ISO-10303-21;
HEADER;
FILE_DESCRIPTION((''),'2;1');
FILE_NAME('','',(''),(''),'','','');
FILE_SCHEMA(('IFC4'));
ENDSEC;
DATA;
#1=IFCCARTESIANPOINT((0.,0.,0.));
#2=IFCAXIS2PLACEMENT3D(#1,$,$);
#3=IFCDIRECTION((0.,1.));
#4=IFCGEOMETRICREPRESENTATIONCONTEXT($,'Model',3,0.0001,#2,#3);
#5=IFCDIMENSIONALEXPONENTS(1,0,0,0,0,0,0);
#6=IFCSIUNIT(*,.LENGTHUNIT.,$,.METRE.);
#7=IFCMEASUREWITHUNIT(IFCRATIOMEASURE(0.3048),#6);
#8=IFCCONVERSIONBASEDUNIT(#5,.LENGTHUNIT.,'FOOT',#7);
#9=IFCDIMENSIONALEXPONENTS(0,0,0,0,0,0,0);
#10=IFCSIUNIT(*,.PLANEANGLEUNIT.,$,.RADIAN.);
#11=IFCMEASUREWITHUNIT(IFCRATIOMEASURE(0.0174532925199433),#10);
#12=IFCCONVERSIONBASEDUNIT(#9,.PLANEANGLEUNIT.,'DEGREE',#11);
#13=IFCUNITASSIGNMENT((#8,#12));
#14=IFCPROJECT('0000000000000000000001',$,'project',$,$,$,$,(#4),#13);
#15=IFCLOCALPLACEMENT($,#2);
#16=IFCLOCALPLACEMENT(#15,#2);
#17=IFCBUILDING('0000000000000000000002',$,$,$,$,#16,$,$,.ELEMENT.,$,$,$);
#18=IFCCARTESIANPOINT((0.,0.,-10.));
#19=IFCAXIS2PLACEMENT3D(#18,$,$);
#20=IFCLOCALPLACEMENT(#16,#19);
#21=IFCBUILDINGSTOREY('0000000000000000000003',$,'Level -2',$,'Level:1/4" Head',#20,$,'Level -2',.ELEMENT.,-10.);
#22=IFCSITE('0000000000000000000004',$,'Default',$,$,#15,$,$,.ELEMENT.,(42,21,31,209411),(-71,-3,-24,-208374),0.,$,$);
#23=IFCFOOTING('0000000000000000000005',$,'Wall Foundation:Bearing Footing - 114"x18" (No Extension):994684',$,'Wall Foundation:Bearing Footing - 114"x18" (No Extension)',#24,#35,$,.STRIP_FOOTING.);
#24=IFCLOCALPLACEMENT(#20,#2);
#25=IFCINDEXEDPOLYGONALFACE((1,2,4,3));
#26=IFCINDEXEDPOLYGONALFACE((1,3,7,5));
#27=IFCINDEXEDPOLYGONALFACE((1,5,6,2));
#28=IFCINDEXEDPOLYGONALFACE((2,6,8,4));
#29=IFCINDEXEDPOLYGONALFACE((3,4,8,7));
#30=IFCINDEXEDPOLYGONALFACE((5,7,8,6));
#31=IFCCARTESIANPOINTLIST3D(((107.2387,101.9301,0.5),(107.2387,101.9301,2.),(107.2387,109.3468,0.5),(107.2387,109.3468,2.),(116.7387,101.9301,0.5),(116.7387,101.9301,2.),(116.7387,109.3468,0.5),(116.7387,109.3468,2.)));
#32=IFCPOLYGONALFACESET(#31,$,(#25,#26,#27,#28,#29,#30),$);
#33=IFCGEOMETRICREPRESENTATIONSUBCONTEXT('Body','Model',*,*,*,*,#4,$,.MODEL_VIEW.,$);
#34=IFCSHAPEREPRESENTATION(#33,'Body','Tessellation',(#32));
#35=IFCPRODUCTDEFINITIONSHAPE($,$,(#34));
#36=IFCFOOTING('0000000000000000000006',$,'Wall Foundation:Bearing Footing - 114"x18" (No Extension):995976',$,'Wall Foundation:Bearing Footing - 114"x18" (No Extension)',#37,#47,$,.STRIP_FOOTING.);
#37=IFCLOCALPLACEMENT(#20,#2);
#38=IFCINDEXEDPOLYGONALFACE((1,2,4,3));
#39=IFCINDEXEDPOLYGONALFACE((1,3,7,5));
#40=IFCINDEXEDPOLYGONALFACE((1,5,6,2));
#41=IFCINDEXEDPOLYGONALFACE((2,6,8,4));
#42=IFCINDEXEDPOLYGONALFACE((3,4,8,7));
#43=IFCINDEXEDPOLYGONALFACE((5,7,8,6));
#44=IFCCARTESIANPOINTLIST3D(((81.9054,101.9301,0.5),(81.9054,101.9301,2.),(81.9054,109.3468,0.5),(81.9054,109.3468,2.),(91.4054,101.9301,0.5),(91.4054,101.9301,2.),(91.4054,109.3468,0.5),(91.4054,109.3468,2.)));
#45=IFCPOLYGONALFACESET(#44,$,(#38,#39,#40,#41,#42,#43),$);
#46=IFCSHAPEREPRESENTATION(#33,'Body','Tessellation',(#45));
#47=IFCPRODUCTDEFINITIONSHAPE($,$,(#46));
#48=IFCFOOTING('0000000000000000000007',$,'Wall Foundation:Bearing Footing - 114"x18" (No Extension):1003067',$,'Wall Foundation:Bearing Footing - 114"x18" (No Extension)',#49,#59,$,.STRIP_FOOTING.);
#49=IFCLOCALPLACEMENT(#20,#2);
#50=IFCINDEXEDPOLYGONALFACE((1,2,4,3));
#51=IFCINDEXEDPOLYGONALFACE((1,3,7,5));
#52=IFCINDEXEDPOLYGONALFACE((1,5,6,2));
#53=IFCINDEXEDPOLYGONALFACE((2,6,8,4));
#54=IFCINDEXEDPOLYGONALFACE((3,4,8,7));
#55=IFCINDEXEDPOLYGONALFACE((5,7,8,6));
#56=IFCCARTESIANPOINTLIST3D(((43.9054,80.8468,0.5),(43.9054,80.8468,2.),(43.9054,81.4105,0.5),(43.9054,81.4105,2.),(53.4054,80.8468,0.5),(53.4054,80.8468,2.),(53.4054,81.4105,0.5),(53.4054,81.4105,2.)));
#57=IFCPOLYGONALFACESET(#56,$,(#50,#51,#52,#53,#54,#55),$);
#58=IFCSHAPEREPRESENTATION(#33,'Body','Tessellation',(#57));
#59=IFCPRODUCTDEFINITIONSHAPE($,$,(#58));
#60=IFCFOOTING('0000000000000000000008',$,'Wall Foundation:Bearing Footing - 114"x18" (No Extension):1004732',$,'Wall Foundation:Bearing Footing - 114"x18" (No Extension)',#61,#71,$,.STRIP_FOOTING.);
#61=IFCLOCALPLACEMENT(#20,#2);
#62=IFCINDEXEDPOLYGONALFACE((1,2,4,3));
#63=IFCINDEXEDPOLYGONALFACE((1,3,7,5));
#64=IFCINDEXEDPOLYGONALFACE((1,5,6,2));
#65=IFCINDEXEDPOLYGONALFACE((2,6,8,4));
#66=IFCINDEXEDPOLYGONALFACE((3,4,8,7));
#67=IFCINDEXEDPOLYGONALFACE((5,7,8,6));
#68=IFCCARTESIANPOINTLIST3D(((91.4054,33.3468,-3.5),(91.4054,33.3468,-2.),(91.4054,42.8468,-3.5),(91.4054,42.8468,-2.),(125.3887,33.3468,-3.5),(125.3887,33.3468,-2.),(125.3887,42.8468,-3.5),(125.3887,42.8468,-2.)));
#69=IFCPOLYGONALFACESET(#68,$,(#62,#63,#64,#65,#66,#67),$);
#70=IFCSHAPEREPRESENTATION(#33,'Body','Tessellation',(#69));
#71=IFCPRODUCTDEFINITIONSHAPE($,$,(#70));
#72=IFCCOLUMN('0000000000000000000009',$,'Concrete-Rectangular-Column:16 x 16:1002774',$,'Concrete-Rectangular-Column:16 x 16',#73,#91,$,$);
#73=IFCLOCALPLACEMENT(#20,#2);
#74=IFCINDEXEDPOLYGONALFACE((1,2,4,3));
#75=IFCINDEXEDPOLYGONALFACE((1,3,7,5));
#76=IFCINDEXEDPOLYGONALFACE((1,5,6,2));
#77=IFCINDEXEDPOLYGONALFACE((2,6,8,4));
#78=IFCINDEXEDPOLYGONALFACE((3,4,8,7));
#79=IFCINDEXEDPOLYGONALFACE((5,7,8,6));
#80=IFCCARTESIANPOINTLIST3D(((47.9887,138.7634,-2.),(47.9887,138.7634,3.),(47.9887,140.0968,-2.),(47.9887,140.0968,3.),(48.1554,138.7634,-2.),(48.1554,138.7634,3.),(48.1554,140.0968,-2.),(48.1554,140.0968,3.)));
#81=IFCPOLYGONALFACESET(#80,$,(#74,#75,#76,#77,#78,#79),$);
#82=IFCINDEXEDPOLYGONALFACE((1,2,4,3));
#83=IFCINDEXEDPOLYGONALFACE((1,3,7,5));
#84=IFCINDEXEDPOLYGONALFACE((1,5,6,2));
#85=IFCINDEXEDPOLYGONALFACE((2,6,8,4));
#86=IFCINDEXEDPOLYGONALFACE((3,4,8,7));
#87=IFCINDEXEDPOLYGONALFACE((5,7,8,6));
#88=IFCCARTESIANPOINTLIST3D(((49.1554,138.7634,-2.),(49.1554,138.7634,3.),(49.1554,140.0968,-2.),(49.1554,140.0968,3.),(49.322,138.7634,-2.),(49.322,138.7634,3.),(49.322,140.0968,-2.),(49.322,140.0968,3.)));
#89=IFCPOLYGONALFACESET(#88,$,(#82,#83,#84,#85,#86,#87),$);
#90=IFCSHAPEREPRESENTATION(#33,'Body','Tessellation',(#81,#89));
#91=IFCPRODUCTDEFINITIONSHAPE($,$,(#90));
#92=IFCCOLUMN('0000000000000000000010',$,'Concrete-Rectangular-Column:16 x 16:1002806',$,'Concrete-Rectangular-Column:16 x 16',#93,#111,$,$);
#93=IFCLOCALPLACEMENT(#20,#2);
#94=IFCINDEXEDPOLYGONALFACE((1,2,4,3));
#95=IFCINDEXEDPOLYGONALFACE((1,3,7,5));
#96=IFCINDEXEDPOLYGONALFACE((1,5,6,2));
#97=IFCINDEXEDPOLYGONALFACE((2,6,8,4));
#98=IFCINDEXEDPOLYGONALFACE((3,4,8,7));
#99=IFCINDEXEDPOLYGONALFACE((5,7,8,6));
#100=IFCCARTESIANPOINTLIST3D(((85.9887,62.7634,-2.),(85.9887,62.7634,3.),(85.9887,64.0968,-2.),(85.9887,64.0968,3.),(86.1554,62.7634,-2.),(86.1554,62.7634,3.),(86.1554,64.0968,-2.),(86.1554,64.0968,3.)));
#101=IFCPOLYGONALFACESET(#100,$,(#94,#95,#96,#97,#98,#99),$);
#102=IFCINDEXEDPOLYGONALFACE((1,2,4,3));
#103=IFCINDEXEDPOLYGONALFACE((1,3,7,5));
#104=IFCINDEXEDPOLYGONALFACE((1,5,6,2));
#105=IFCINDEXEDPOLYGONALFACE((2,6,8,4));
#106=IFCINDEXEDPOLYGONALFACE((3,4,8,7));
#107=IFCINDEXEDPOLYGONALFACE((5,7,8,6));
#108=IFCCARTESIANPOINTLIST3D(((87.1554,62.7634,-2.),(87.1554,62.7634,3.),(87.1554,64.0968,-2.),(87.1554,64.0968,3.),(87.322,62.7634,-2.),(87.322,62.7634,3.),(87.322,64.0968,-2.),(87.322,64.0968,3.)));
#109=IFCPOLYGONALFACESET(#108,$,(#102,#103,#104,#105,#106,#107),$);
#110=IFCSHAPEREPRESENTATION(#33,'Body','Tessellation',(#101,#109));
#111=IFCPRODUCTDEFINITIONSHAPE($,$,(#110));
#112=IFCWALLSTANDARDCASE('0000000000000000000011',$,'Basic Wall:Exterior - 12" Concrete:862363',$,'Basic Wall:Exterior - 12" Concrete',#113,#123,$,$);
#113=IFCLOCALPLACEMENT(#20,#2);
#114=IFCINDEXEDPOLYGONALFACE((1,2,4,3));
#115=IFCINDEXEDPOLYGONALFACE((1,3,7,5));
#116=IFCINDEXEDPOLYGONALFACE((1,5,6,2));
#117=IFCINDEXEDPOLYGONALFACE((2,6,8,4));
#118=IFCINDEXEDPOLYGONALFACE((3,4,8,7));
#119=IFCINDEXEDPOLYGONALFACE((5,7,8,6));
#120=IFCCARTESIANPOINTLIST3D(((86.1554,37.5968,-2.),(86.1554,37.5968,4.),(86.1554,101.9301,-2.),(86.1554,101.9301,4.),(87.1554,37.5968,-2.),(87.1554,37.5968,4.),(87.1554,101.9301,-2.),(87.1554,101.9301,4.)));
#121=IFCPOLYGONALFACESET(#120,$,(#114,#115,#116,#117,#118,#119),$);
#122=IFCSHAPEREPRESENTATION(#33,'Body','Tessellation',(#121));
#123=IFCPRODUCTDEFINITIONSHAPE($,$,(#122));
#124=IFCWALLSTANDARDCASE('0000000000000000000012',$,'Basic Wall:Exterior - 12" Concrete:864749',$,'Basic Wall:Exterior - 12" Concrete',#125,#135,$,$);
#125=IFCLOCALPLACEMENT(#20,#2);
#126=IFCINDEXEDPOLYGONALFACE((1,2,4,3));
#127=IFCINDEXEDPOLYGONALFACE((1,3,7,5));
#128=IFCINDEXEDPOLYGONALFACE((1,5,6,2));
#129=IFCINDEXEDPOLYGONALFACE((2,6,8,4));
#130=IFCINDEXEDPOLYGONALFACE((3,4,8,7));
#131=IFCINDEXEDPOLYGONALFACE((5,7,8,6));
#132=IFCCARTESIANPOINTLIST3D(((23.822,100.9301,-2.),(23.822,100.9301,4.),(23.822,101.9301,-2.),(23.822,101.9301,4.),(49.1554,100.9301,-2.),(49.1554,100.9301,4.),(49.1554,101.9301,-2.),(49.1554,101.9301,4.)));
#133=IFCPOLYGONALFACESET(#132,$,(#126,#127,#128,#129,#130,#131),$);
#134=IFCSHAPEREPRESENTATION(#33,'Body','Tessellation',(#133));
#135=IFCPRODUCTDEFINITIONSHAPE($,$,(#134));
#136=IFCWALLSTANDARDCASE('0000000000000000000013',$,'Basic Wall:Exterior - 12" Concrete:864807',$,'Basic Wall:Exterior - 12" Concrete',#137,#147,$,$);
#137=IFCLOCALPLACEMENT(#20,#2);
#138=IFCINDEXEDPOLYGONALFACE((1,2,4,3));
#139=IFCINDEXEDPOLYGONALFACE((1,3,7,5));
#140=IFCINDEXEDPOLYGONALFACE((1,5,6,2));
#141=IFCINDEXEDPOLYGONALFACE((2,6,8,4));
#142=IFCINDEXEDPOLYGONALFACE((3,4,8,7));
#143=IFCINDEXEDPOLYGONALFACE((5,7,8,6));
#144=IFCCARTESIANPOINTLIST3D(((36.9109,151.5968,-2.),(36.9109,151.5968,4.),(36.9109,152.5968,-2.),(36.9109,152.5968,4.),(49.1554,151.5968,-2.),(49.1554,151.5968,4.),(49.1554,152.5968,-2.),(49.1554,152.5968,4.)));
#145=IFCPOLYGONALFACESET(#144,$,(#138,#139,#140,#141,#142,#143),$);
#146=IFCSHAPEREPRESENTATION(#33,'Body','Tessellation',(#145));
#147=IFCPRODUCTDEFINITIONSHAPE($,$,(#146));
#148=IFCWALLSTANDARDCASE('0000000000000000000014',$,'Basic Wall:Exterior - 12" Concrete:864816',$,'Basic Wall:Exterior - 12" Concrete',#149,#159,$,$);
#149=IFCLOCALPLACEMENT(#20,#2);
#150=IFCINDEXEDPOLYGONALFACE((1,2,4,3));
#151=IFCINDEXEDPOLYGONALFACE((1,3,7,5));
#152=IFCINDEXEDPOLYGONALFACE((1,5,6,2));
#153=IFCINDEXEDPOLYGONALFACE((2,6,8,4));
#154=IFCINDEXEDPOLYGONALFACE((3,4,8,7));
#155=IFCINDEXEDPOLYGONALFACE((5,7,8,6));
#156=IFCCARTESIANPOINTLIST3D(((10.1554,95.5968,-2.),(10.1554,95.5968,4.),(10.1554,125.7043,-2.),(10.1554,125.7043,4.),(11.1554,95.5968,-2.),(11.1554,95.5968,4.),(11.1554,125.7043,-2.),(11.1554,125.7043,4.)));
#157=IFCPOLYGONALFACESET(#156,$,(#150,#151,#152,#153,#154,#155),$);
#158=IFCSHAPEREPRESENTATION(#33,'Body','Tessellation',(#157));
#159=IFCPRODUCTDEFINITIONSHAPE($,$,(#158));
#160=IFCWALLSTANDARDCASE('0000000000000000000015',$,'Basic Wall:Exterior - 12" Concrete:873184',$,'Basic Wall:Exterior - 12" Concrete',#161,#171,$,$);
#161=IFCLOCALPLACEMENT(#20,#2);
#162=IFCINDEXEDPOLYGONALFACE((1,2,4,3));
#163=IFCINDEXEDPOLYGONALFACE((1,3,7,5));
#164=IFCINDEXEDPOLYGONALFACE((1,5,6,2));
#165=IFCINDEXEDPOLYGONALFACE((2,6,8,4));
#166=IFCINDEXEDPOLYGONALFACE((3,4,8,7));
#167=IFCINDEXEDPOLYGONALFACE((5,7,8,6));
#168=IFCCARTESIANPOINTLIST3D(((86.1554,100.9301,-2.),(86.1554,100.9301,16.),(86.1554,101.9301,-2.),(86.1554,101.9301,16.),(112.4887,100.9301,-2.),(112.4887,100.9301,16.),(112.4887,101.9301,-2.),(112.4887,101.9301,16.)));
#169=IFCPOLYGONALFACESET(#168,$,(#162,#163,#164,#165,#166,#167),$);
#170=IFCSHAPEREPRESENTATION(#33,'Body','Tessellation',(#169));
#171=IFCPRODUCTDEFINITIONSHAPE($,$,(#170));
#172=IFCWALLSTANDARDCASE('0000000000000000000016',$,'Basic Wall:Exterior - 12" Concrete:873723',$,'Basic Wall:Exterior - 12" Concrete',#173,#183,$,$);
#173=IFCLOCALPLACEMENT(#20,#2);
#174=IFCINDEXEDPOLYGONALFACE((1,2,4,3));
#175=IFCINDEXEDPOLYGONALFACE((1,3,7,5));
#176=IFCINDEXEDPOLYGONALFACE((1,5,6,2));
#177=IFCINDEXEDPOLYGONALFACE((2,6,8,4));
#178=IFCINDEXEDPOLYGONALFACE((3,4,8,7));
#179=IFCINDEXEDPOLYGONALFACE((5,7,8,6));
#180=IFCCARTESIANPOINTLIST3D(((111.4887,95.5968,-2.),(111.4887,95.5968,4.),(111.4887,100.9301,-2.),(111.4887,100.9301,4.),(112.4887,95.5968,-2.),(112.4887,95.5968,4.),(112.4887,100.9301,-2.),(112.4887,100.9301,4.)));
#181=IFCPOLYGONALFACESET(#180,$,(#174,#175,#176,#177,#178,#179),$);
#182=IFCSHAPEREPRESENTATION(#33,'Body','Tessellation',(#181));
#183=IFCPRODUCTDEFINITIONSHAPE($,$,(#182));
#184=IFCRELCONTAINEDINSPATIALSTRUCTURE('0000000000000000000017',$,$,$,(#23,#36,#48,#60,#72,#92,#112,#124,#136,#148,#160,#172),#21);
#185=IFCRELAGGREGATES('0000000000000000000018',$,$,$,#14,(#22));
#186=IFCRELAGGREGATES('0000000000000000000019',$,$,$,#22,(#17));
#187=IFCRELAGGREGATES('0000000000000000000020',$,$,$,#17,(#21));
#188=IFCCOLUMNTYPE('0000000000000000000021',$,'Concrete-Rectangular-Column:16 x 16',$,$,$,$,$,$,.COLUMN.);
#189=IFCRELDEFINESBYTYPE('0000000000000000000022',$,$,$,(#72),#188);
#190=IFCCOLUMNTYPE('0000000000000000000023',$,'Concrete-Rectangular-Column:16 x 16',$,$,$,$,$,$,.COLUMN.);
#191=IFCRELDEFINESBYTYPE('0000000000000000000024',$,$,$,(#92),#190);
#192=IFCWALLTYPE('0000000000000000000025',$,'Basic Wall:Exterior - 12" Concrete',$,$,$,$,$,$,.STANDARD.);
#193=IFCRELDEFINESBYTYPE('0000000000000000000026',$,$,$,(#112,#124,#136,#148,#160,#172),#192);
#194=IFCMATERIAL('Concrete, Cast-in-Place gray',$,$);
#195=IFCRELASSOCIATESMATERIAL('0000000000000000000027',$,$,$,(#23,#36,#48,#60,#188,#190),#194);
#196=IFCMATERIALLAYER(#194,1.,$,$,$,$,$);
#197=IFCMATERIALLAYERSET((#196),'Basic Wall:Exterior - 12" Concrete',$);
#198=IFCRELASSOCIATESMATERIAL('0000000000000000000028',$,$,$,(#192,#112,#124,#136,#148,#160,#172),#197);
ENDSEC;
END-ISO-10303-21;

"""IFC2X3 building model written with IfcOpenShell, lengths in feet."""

from ifc_helpers import new_model, entity, si_unit, converted_unit, direction, frame, frame_2d, origin, origin_2d_with_axis, place, context, subcontext, project, spatial, rectangle, extrude, source, transform, mapped, material, layer, layer_set, layer_usage, type_object, type_shapes, element, save


model = new_model("IFC2X3")

# Units and contexts
model_context = context("Model", 3, precision=0.0001, world=origin(), true_north=direction((0.0, 1.0)))
body_context = subcontext(model_context, "Body", "Model", "MODEL_VIEW")
ifc_project = project(units=[converted_unit("LENGTHUNIT", "FOOT", entity("IfcRatioMeasure", 0.3048), si_unit("LENGTHUNIT", "METRE"), dimensions=[1, 0, 0, 0, 0, 0, 0]), converted_unit("PLANEANGLEUNIT", "DEGREE", entity("IfcRatioMeasure", 0.0174532925199433), si_unit("PLANEANGLEUNIT", "RADIAN"), dimensions=[0, 0, 0, 0, 0, 0, 0])], contexts=[model_context])

# Site, building, storey
site_placement = place(None, origin())
site = spatial("IfcSite", under=ifc_project, at=site_placement, Name="Default", CompositionType="ELEMENT", RefLatitude=(42, 21, 31, 209411), RefLongitude=(-71, -3, -24, -208374), RefElevation=0.0)
building_placement = place(site_placement, origin())
building = spatial("IfcBuilding", under=site, at=building_placement, CompositionType="ELEMENT")
storey_placement = place(building_placement, frame((0.0, 0.0, -10.0)))
storey = spatial("IfcBuildingStorey", under=building, at=storey_placement, Name="Level -2", ObjectType="Level:1/4\" Head", LongName="Level -2", CompositionType="ELEMENT", Elevation=-10.0)

# Footings
ifc_material = material(Name="Concrete, Cast-in-Place gray")
footing_1_placement = place(storey_placement, origin())
element("IfcFooting", 1, at=footing_1_placement, inside=storey, material=ifc_material, Name="Wall Foundation:Bearing Footing - 114\"x18\" (No Extension):994684", ObjectType="Wall Foundation:Bearing Footing - 114\"x18\" (No Extension)", PredefinedType="STRIP_FOOTING", context=body_context, shape_type="SweptSolid", body=[
    extrude(rectangle(XDim=7.4167, YDim=9.5, at=frame_2d((0.0, 0.0), x_axis=(1.0, 0.0))), frame((111.9887, 105.6384, 0.5), z_axis=(0.0, 0.0, 1.0), x_axis=(0.0, 1.0, 0.0)), (0.0, 0.0, 1.0), 1.5),
])
footing_2_placement = place(storey_placement, origin())
element("IfcFooting", 2, at=footing_2_placement, inside=storey, material=ifc_material, Name="Wall Foundation:Bearing Footing - 114\"x18\" (No Extension):995976", ObjectType="Wall Foundation:Bearing Footing - 114\"x18\" (No Extension)", PredefinedType="STRIP_FOOTING", context=body_context, shape_type="SweptSolid", body=[
    extrude(rectangle(XDim=7.4167, YDim=9.5, at=frame_2d((0.0, 0.0), x_axis=(1.0, 0.0))), frame((86.6554, 105.6384, 0.5), z_axis=(0.0, 0.0, 1.0), x_axis=(0.0, 1.0, 0.0)), (0.0, 0.0, 1.0), 1.5),
])
footing_3_placement = place(storey_placement, origin())
element("IfcFooting", 3, at=footing_3_placement, inside=storey, material=ifc_material, Name="Wall Foundation:Bearing Footing - 114\"x18\" (No Extension):1003067", ObjectType="Wall Foundation:Bearing Footing - 114\"x18\" (No Extension)", PredefinedType="STRIP_FOOTING", context=body_context, shape_type="SweptSolid", body=[
    extrude(rectangle(XDim=0.5637, YDim=9.5, at=frame_2d((0.0, 0.0), x_axis=(1.0, 0.0))), frame((48.6554, 81.1286, 0.5), z_axis=(0.0, 0.0, 1.0), x_axis=(0.0, -1.0, 0.0)), (0.0, 0.0, 1.0), 1.5),
])
footing_4_placement = place(storey_placement, origin())
element("IfcFooting", 4, at=footing_4_placement, inside=storey, material=ifc_material, Name="Wall Foundation:Bearing Footing - 114\"x18\" (No Extension):1004732", ObjectType="Wall Foundation:Bearing Footing - 114\"x18\" (No Extension)", PredefinedType="STRIP_FOOTING", context=body_context, shape_type="SweptSolid", body=[
    extrude(rectangle(XDim=33.9833, YDim=9.5, at=frame_2d((0.0, 0.0), x_axis=(1.0, 0.0))), frame((108.397, 38.0968, -3.5), z_axis=(0.0, 0.0, 1.0), x_axis=(-1.0, 0.0, 0.0)), (0.0, 0.0, 1.0), 1.5),
])

# Columns
column_type_1 = type_object("IfcColumnType", Name="Concrete-Rectangular-Column:16 x 16", PredefinedType="COLUMN", material=ifc_material)
shared_shape_1 = source(origin(), body_context, "Body", "SweptSolid", [
    extrude(rectangle(XDim=1.3333, YDim=0.1667, at=frame_2d((0.0, 0.0), x_axis=(1.0, 0.0))), frame((48.072, 139.4301, -12.0), z_axis=(0.0, 0.0, 1.0), x_axis=(0.0, -1.0, 0.0)), (0.0, 0.0, 1.0), 5.0),
    extrude(rectangle(XDim=1.3333, YDim=0.1667, at=origin_2d_with_axis()), frame((49.2387, 139.4301, -12.0), z_axis=(0.0, 0.0, 1.0), x_axis=(0.0, -1.0, 0.0)), (0.0, 0.0, 1.0), 5.0),
])
type_shapes(column_type_1, [shared_shape_1])
column_1_placement = place(storey_placement, frame((0.0, 0.0, 10.0)))
element("IfcColumn", 5, at=column_1_placement, inside=storey, type_object=column_type_1, Name="Concrete-Rectangular-Column:16 x 16:1002774", ObjectType="Concrete-Rectangular-Column:16 x 16", context=body_context, shape_type="MappedRepresentation", body=[
    mapped(shared_shape_1, transform((0.0, 0.0, 0.0), scale=1.0)),
])
column_type_2 = type_object("IfcColumnType", Name="Concrete-Rectangular-Column:16 x 16", PredefinedType="COLUMN", material=ifc_material)
shared_shape_2 = source(origin(), body_context, "Body", "SweptSolid", [
    extrude(rectangle(XDim=1.3333, YDim=0.1667, at=frame_2d((0.0, 0.0), x_axis=(1.0, 0.0))), frame((86.072, 63.4301, -12.0), z_axis=(0.0, 0.0, 1.0), x_axis=(0.0, -1.0, 0.0)), (0.0, 0.0, 1.0), 5.0),
    extrude(rectangle(XDim=1.3333, YDim=0.1667, at=frame_2d((0.0, 0.0), x_axis=(1.0, 0.0))), frame((87.2387, 63.4301, -12.0), z_axis=(0.0, 0.0, 1.0), x_axis=(0.0, -1.0, 0.0)), (0.0, 0.0, 1.0), 5.0),
])
type_shapes(column_type_2, [shared_shape_2])
column_2_placement = place(storey_placement, frame((0.0, 0.0, 10.0)))
element("IfcColumn", 6, at=column_2_placement, inside=storey, type_object=column_type_2, Name="Concrete-Rectangular-Column:16 x 16:1002806", ObjectType="Concrete-Rectangular-Column:16 x 16", context=body_context, shape_type="MappedRepresentation", body=[
    mapped(shared_shape_2, transform((0.0, 0.0, 0.0), scale=1.0)),
])

# Walls
ifc_layer_1 = layer(ifc_material, 1.0)
ifc_layer_set_1 = layer_set([ifc_layer_1], Name="Basic Wall:Exterior - 12\" Concrete")
ifc_layer_usage_1 = layer_usage(ifc_layer_set_1, "AXIS2", "NEGATIVE", 0.5)
wall_type_1 = type_object("IfcWallType", Name="Basic Wall:Exterior - 12\" Concrete", PredefinedType="STANDARD", material=ifc_layer_set_1)
wall_1_placement = place(storey_placement, frame((86.6554, 101.9301, -2.0), z_axis=(0.0, 0.0, 1.0), x_axis=(0.0, -1.0, 0.0)))
element("IfcWallStandardCase", 7, at=wall_1_placement, inside=storey, type_object=wall_type_1, material=ifc_layer_usage_1, Name="Basic Wall:Exterior - 12\" Concrete:862363", ObjectType="Basic Wall:Exterior - 12\" Concrete", context=body_context, shape_type="SweptSolid", body=[
    extrude(rectangle(XDim=64.3333, YDim=1.0, at=frame_2d((32.1667, 0.0), x_axis=(-1.0, 0.0))), origin(), (0.0, 0.0, 1.0), 6.0),
])
ifc_layer_usage_2 = layer_usage(ifc_layer_set_1, "AXIS2", "NEGATIVE", 0.5)
wall_2_placement = place(storey_placement, frame((49.1554, 101.4301, -2.0), z_axis=(0.0, 0.0, 1.0), x_axis=(-1.0, 0.0, 0.0)))
element("IfcWallStandardCase", 8, at=wall_2_placement, inside=storey, type_object=wall_type_1, material=ifc_layer_usage_2, Name="Basic Wall:Exterior - 12\" Concrete:864749", ObjectType="Basic Wall:Exterior - 12\" Concrete", context=body_context, shape_type="SweptSolid", body=[
    extrude(rectangle(XDim=25.3333, YDim=1.0, at=frame_2d((12.6667, 0.0), x_axis=(-1.0, 0.0))), origin(), (0.0, 0.0, 1.0), 6.0),
])
ifc_layer_usage_3 = layer_usage(ifc_layer_set_1, "AXIS2", "NEGATIVE", 0.5)
wall_3_placement = place(storey_placement, frame((49.1554, 152.0968, -2.0), z_axis=(0.0, 0.0, 1.0), x_axis=(-1.0, 0.0, 0.0)))
element("IfcWallStandardCase", 9, at=wall_3_placement, inside=storey, type_object=wall_type_1, material=ifc_layer_usage_3, Name="Basic Wall:Exterior - 12\" Concrete:864807", ObjectType="Basic Wall:Exterior - 12\" Concrete", context=body_context, shape_type="SweptSolid", body=[
    extrude(rectangle(XDim=12.2444, YDim=1.0, at=frame_2d((6.1222, 0.0), x_axis=(-1.0, 0.0))), origin(), (0.0, 0.0, 1.0), 6.0),
])
ifc_layer_usage_4 = layer_usage(ifc_layer_set_1, "AXIS2", "NEGATIVE", 0.5)
wall_4_placement = place(storey_placement, frame((10.6554, 125.7043, -2.0), z_axis=(0.0, 0.0, 1.0), x_axis=(0.0, -1.0, 0.0)))
element("IfcWallStandardCase", 10, at=wall_4_placement, inside=storey, type_object=wall_type_1, material=ifc_layer_usage_4, Name="Basic Wall:Exterior - 12\" Concrete:864816", ObjectType="Basic Wall:Exterior - 12\" Concrete", context=body_context, shape_type="SweptSolid", body=[
    extrude(rectangle(XDim=30.1075, YDim=1.0, at=frame_2d((15.0538, 0.0), x_axis=(-1.0, 0.0))), origin(), (0.0, 0.0, 1.0), 6.0),
])
ifc_layer_usage_5 = layer_usage(ifc_layer_set_1, "AXIS2", "NEGATIVE", 0.5)
wall_5_placement = place(storey_placement, frame((112.4887, 101.4301, -2.0), z_axis=(0.0, 0.0, 1.0), x_axis=(-1.0, 0.0, 0.0)))
element("IfcWallStandardCase", 11, at=wall_5_placement, inside=storey, type_object=wall_type_1, material=ifc_layer_usage_5, Name="Basic Wall:Exterior - 12\" Concrete:873184", ObjectType="Basic Wall:Exterior - 12\" Concrete", context=body_context, shape_type="SweptSolid", body=[
    extrude(rectangle(XDim=26.3333, YDim=1.0, at=frame_2d((13.1667, 0.0), x_axis=(-1.0, 0.0))), origin(), (0.0, 0.0, 1.0), 18.0),
])
ifc_layer_usage_6 = layer_usage(ifc_layer_set_1, "AXIS2", "NEGATIVE", 0.5)
wall_6_placement = place(storey_placement, frame((111.9887, 95.5968, -2.0), z_axis=(0.0, 0.0, 1.0), x_axis=(0.0, 1.0, 0.0)))
element("IfcWallStandardCase", 12, at=wall_6_placement, inside=storey, type_object=wall_type_1, material=ifc_layer_usage_6, Name="Basic Wall:Exterior - 12\" Concrete:873723", ObjectType="Basic Wall:Exterior - 12\" Concrete", context=body_context, shape_type="SweptSolid", body=[
    extrude(rectangle(XDim=5.3333, YDim=1.0, at=frame_2d((2.6667, 0.0), x_axis=(-1.0, 0.0))), origin(), (0.0, 0.0, 1.0), 6.0),
])

save(model, "model.ifc")
